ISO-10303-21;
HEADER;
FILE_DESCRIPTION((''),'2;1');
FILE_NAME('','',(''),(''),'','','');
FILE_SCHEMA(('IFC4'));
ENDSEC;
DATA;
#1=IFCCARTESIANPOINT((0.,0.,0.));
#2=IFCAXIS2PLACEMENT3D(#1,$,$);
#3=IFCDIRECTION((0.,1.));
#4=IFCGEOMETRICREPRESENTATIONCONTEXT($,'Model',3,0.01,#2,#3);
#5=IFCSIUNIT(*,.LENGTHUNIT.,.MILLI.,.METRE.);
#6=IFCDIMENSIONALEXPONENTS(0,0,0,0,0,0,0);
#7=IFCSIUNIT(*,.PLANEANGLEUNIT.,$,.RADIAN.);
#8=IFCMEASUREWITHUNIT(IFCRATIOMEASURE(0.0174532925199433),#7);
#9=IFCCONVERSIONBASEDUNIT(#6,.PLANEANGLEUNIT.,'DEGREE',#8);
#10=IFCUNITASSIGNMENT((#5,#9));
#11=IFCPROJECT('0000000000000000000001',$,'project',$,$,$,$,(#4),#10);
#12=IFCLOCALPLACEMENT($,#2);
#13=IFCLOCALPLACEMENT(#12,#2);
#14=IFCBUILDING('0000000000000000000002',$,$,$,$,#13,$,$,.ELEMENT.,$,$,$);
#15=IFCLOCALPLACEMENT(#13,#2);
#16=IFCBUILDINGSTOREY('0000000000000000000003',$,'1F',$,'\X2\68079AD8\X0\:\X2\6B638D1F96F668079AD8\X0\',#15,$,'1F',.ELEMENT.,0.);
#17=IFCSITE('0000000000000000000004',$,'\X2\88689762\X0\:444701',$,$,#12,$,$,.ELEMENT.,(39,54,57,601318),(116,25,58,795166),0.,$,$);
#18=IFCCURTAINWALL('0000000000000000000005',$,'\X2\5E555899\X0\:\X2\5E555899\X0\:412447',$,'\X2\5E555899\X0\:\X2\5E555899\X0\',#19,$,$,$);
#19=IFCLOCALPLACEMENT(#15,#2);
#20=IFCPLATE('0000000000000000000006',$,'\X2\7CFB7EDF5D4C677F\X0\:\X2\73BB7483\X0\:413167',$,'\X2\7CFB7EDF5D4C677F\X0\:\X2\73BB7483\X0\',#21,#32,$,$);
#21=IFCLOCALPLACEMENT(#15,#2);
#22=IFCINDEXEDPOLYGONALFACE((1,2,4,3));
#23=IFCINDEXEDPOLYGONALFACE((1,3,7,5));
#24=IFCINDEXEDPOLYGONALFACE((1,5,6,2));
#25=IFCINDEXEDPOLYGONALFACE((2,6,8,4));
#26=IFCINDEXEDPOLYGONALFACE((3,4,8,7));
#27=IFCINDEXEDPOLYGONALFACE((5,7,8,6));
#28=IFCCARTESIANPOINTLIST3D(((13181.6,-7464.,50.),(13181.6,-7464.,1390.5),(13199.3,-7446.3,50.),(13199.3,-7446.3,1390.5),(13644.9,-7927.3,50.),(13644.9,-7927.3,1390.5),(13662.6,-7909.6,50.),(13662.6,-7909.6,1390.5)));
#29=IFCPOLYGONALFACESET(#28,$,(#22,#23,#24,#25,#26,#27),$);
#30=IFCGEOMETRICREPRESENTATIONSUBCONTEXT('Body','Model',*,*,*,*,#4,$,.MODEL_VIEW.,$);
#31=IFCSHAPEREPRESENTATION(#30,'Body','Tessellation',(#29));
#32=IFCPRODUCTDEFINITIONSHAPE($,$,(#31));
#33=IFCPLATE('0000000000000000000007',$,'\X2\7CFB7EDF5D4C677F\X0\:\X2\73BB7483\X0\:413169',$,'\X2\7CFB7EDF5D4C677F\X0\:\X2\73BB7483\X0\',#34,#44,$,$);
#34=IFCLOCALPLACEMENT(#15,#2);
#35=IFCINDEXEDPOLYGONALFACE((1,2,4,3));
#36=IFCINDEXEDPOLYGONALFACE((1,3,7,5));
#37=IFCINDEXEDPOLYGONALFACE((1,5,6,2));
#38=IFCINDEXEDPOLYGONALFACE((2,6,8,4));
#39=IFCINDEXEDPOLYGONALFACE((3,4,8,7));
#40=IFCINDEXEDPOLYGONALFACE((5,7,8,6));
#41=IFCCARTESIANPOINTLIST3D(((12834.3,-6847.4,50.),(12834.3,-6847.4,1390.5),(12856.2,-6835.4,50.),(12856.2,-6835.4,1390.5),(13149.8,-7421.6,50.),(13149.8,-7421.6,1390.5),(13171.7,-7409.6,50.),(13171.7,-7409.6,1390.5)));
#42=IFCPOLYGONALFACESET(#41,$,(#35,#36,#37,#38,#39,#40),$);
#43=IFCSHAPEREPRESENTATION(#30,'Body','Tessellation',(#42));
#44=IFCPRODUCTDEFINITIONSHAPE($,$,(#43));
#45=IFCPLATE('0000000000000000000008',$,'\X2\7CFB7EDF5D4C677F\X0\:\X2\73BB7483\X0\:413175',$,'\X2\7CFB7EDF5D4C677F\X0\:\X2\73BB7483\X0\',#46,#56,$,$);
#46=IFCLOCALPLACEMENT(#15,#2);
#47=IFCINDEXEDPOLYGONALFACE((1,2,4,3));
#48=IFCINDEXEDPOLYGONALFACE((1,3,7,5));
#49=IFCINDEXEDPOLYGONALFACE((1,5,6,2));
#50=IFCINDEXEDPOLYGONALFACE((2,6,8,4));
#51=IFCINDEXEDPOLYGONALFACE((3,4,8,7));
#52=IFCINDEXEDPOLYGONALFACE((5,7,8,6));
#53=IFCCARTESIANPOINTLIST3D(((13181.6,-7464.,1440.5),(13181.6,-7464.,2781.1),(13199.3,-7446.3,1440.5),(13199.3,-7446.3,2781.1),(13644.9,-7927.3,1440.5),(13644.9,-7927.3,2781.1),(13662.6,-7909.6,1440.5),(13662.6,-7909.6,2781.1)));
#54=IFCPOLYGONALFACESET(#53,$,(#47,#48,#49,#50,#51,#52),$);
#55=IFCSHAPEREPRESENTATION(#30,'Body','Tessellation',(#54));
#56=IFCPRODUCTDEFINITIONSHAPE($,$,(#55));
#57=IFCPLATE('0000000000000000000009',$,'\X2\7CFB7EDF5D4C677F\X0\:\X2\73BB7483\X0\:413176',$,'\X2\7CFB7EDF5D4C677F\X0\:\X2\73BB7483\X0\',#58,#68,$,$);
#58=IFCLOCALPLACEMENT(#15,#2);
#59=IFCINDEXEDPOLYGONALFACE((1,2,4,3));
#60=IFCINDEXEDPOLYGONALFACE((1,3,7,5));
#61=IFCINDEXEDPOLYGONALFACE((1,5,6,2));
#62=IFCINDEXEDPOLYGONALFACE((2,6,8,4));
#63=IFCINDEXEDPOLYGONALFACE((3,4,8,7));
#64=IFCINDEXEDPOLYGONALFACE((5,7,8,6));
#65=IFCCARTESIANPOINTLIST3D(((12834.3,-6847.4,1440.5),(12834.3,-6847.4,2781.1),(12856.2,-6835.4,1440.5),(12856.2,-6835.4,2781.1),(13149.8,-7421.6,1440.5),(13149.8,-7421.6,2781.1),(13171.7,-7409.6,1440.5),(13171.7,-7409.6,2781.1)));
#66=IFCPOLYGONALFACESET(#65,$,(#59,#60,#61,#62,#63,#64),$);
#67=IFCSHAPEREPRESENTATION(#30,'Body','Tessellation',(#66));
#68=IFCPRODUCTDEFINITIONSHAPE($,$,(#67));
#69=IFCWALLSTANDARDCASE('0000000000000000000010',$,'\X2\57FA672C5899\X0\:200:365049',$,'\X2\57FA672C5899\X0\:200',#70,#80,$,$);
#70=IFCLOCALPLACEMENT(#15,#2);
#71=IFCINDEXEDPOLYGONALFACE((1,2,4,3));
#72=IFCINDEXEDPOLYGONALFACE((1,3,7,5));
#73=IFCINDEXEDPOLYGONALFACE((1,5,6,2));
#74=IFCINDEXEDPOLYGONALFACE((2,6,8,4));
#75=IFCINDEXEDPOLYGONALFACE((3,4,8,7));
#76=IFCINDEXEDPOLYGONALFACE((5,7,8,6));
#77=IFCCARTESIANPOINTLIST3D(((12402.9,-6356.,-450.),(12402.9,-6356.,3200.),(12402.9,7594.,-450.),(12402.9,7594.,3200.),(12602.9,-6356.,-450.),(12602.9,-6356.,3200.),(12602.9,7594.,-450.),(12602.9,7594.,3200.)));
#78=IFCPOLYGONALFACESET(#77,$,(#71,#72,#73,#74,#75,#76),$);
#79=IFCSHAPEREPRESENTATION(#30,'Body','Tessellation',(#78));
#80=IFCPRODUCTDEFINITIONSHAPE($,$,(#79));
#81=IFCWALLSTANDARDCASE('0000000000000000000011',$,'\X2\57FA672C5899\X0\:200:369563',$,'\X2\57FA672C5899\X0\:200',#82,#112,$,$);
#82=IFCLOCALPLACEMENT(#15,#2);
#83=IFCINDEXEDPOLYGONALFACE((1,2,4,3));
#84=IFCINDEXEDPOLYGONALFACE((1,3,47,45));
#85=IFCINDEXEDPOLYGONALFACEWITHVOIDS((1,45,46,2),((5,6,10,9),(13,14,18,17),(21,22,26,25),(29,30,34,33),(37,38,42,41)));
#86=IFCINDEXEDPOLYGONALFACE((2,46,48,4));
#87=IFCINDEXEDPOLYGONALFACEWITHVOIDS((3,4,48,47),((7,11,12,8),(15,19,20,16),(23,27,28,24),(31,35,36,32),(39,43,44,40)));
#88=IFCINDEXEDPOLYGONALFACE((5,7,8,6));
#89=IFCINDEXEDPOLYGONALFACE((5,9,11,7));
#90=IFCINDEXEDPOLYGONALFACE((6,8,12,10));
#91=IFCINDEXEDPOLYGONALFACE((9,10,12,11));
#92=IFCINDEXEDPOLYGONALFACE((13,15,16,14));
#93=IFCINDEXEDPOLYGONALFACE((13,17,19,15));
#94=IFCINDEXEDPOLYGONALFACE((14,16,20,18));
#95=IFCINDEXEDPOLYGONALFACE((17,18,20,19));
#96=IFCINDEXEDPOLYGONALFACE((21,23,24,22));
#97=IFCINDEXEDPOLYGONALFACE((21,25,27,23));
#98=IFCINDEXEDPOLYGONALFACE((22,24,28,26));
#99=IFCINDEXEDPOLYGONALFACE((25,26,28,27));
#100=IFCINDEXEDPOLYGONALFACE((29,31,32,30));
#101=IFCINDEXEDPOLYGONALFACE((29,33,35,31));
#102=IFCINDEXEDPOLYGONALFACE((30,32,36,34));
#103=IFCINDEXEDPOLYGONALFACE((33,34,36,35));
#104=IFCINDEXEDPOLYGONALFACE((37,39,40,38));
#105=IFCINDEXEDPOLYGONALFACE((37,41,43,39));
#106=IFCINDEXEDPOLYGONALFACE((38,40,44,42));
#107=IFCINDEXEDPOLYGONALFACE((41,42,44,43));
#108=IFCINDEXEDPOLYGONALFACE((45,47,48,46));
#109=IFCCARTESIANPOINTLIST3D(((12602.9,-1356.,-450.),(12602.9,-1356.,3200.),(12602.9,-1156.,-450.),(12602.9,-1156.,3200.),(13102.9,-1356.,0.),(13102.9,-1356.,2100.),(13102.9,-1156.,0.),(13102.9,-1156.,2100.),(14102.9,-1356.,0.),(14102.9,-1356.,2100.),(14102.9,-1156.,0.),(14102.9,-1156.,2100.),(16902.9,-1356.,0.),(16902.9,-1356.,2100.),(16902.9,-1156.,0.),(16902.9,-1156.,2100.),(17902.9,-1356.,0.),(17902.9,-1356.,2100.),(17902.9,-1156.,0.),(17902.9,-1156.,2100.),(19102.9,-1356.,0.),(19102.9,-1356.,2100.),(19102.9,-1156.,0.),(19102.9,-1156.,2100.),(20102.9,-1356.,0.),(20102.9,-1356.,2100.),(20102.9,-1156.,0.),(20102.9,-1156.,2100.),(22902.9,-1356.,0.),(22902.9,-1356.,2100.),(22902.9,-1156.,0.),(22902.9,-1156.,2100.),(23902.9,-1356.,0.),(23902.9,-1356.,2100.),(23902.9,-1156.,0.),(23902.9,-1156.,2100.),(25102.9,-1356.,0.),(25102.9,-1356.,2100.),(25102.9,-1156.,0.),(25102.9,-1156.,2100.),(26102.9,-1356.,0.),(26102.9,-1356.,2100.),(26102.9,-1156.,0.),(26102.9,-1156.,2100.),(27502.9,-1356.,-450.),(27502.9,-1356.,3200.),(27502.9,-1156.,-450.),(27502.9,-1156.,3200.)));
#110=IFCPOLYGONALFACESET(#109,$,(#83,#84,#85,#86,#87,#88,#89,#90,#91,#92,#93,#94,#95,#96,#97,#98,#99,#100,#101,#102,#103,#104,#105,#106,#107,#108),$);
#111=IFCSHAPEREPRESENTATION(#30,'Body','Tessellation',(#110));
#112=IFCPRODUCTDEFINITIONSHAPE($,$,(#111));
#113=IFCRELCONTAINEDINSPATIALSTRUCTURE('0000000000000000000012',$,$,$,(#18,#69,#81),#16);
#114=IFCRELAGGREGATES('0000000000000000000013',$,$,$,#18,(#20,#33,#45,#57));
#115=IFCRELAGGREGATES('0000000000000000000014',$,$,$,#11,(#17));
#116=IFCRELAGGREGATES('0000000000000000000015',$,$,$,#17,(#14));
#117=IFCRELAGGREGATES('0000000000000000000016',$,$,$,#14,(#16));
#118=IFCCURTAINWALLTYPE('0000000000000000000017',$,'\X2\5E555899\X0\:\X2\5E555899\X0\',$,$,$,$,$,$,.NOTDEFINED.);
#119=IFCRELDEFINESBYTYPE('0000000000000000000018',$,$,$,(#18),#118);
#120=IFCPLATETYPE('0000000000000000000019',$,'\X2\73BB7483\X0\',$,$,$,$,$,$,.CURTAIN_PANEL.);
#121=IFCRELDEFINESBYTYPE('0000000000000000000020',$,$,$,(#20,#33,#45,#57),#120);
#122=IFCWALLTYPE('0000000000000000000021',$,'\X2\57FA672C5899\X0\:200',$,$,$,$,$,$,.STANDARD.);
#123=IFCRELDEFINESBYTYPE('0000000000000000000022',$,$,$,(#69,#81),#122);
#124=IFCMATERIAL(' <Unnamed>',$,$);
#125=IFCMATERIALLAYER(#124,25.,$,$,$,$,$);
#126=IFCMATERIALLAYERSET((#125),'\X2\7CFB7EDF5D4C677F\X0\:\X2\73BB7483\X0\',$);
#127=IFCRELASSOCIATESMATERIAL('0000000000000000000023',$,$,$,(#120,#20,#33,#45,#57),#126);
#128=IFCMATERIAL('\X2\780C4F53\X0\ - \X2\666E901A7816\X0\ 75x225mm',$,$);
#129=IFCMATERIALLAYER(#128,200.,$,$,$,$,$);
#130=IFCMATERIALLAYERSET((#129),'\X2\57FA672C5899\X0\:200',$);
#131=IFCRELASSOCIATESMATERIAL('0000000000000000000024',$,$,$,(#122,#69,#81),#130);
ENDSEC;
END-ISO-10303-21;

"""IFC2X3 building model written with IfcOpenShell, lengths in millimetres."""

from ifc_helpers import new_model, entity, si_unit, converted_unit, direction, frame, frame_2d, origin, place, context, subcontext, project, spatial, rectangle, extrude, source, transform, mapped, material, layer, layer_set, layer_usage, type_object, type_shapes, element, aggregate, save


model = new_model("IFC2X3")

# Units and contexts
model_context = context("Model", 3, precision=0.01, world=origin(), true_north=direction((0.0, 1.0)))
body_context = subcontext(model_context, "Body", "Model", "MODEL_VIEW")
ifc_project = project(units=[si_unit("LENGTHUNIT", "METRE", prefix="MILLI"), converted_unit("PLANEANGLEUNIT", "DEGREE", entity("IfcRatioMeasure", 0.0174532925199433), si_unit("PLANEANGLEUNIT", "RADIAN"), dimensions=[0, 0, 0, 0, 0, 0, 0])], contexts=[model_context])

# Site, building, storey
site_placement = place(None, origin())
site = spatial("IfcSite", under=ifc_project, at=site_placement, Name="表面:444701", CompositionType="ELEMENT", RefLatitude=(39, 54, 57, 601318), RefLongitude=(116, 25, 58, 795166), RefElevation=0.0)
building_placement = place(site_placement, origin())
building = spatial("IfcBuilding", under=site, at=building_placement, CompositionType="ELEMENT")
storey_placement = place(building_placement, origin())
storey = spatial("IfcBuildingStorey", under=building, at=storey_placement, Name="1F", ObjectType="标高:正负零标高", LongName="1F", CompositionType="ELEMENT", Elevation=0.0)

# Curtain wall, plates
curtain_wall_type = type_object("IfcCurtainWallType", Name="幕墙:幕墙", PredefinedType="NOTDEFINED")
curtain_wall_placement = place(storey_placement, origin())
curtain_wall = element("IfcCurtainWall", 1, at=curtain_wall_placement, inside=storey, type_object=curtain_wall_type, Name="幕墙:幕墙:412447", ObjectType="幕墙:幕墙")
ifc_material_1 = material(Name=" <Unnamed>")
ifc_layer_1 = layer(ifc_material_1, 25.0)
ifc_layer_set_1 = layer_set([ifc_layer_1], Name="系统嵌板:玻璃")
ifc_layer_usage_1 = layer_usage(ifc_layer_set_1, "AXIS3", "POSITIVE", 0.0)
plate_type_1 = type_object("IfcPlateType", Name="玻璃", PredefinedType="CURTAIN_PANEL", material=ifc_layer_set_1)
shared_shape_1 = source(origin(), body_context, "Body", "SweptSolid", [
    extrude(rectangle(XDim=25.0, YDim=655.2, at=frame_2d((0.0, 0.0), x_axis=(1.0, 0.0))), frame((0.0, 0.0, 0.0), z_axis=(0.0, 0.0, 1.0), x_axis=(0.0, 1.0, 0.0)), (0.0, 0.0, 1.0), 1340.5),
])
type_shapes(plate_type_1, [shared_shape_1])
plate_1_placement = place(curtain_wall_placement, frame((13422.1, -7686.8, 50.0), z_axis=(0.0, 0.0, 1.0), x_axis=(-0.707107, 0.707107, 0.0)))
plate_1 = element("IfcPlate", 2, at=plate_1_placement, type_object=plate_type_1, material=ifc_layer_usage_1, Name="系统嵌板:玻璃:413167", ObjectType="系统嵌板:玻璃", context=body_context, shape_type="MappedRepresentation", body=[
    mapped(shared_shape_1, transform((0.0, 0.0, 0.0), scale=1.0)),
])
ifc_layer_usage_2 = layer_usage(ifc_layer_set_1, "AXIS3", "POSITIVE", 0.0)
plate_2_placement = place(curtain_wall_placement, frame((13003.0, -7128.5, 50.0), z_axis=(0.0, 0.0, 1.0), x_axis=(-0.481516, 0.876437, 0.0)))
plate_2 = element("IfcPlate", 3, at=plate_2_placement, type_object=plate_type_1, material=ifc_layer_usage_2, Name="系统嵌板:玻璃:413169", ObjectType="系统嵌板:玻璃", context=body_context, shape_type="MappedRepresentation", body=[
    mapped(shared_shape_1, transform((0.0, 0.0, 0.0), scale=1.0)),
])
ifc_layer_usage_3 = layer_usage(ifc_layer_set_1, "AXIS3", "POSITIVE", 0.0)
plate_3_placement = place(curtain_wall_placement, frame((13422.1, -7686.8, 1440.5), z_axis=(0.0, 0.0, 1.0), x_axis=(-0.707107, 0.707107, 0.0)))
plate_3 = element("IfcPlate", 4, at=plate_3_placement, type_object=plate_type_1, material=ifc_layer_usage_3, Name="系统嵌板:玻璃:413175", ObjectType="系统嵌板:玻璃", context=body_context, shape_type="MappedRepresentation", body=[
    mapped(shared_shape_1, transform((0.0, 0.0, 0.0), scale=1.0)),
])
ifc_layer_usage_4 = layer_usage(ifc_layer_set_1, "AXIS3", "POSITIVE", 0.0)
plate_4_placement = place(curtain_wall_placement, frame((13003.0, -7128.5, 1440.5), z_axis=(0.0, 0.0, 1.0), x_axis=(-0.481516, 0.876437, 0.0)))
plate_4 = element("IfcPlate", 5, at=plate_4_placement, type_object=plate_type_1, material=ifc_layer_usage_4, Name="系统嵌板:玻璃:413176", ObjectType="系统嵌板:玻璃", context=body_context, shape_type="MappedRepresentation", body=[
    mapped(shared_shape_1, transform((0.0, 0.0, 0.0), scale=1.0)),
])
aggregate(curtain_wall, [plate_1, plate_2, plate_3, plate_4])

# Wall
ifc_material_2 = material(Name="砌体 - 普通砖 75x225mm")
ifc_layer_2 = layer(ifc_material_2, 200.0)
ifc_layer_set_2 = layer_set([ifc_layer_2], Name="基本墙:200")
ifc_layer_usage_5 = layer_usage(ifc_layer_set_2, "AXIS2", "NEGATIVE", 100.0)
wall_type = type_object("IfcWallType", Name="基本墙:200", PredefinedType="STANDARD", material=ifc_layer_set_2)
wall_1_placement = place(storey_placement, frame((12502.9, -6356.0, -450.0), z_axis=(0.0, 0.0, 1.0), x_axis=(0.0, 1.0, 0.0)))
element("IfcWallStandardCase", 6, at=wall_1_placement, inside=storey, type_object=wall_type, material=ifc_layer_usage_5, Name="基本墙:200:365049", ObjectType="基本墙:200", context=body_context, shape_type="SweptSolid", body=[
    extrude(rectangle(XDim=13950.0, YDim=200.0, at=frame_2d((6975.0, 0.0), x_axis=(-1.0, 0.0))), origin(), (0.0, 0.0, 1.0), 3650.0),
])

# Wall, openings
ifc_layer_usage_6 = layer_usage(ifc_layer_set_2, "AXIS2", "NEGATIVE", 100.0)
wall_2_placement = place(storey_placement, frame((12602.9, -1256.0, -450.0)))
wall_2 = element("IfcWallStandardCase", 7, at=wall_2_placement, inside=storey, type_object=wall_type, material=ifc_layer_usage_6, Name="基本墙:200:369563", ObjectType="基本墙:200", context=body_context, shape_type="SweptSolid", body=[
    extrude(rectangle(XDim=14900.0, YDim=200.0, at=frame_2d((7450.0, 0.0), x_axis=(-1.0, 0.0))), origin(), (0.0, 0.0, 1.0), 3650.0),
])
opening_1_placement = place(wall_2_placement, frame((13500.0, 100.0, 450.0)))
element("IfcOpeningElement", 8, at=opening_1_placement, cuts=wall_2, ObjectType="Opening", context=body_context, shape_type="SweptSolid", body=[
    extrude(rectangle(XDim=2100.0, YDim=1000.0, at=frame_2d((1050.0, 500.0), x_axis=(1.0, 0.0))), frame((0.0, 0.0, 0.0), z_axis=(0.0, -1.0, 0.0), x_axis=(0.0, 0.0, 1.0)), (0.0, 0.0, 1.0), 200.0),
])
opening_2_placement = place(wall_2_placement, frame((11300.0, 100.0, 450.0)))
element("IfcOpeningElement", 9, at=opening_2_placement, cuts=wall_2, ObjectType="Opening", context=body_context, shape_type="SweptSolid", body=[
    extrude(rectangle(XDim=2100.0, YDim=1000.0, at=frame_2d((1050.0, 500.0), x_axis=(1.0, 0.0))), frame((0.0, 0.0, 0.0), z_axis=(0.0, -1.0, 0.0), x_axis=(0.0, 0.0, 1.0)), (0.0, 0.0, 1.0), 200.0),
])
opening_3_placement = place(wall_2_placement, frame((7500.0, 100.0, 450.0)))
element("IfcOpeningElement", 10, at=opening_3_placement, cuts=wall_2, ObjectType="Opening", context=body_context, shape_type="SweptSolid", body=[
    extrude(rectangle(XDim=2100.0, YDim=1000.0, at=frame_2d((1050.0, 500.0), x_axis=(1.0, 0.0))), frame((0.0, 0.0, 0.0), z_axis=(0.0, -1.0, 0.0), x_axis=(0.0, 0.0, 1.0)), (0.0, 0.0, 1.0), 200.0),
])
opening_4_placement = place(wall_2_placement, frame((5300.0, 100.0, 450.0)))
element("IfcOpeningElement", 11, at=opening_4_placement, cuts=wall_2, ObjectType="Opening", context=body_context, shape_type="SweptSolid", body=[
    extrude(rectangle(XDim=2100.0, YDim=1000.0, at=frame_2d((1050.0, 500.0), x_axis=(1.0, 0.0))), frame((0.0, 0.0, 0.0), z_axis=(0.0, -1.0, 0.0), x_axis=(0.0, 0.0, 1.0)), (0.0, 0.0, 1.0), 200.0),
])
opening_5_placement = place(wall_2_placement, frame((1500.0, 100.0, 450.0)))
element("IfcOpeningElement", 12, at=opening_5_placement, cuts=wall_2, ObjectType="Opening", context=body_context, shape_type="SweptSolid", body=[
    extrude(rectangle(XDim=2100.0, YDim=1000.0, at=frame_2d((1050.0, 500.0), x_axis=(1.0, 0.0))), frame((0.0, 0.0, 0.0), z_axis=(0.0, -1.0, 0.0), x_axis=(0.0, 0.0, 1.0)), (0.0, 0.0, 1.0), 200.0),
])

save(model, "model.ifc")
